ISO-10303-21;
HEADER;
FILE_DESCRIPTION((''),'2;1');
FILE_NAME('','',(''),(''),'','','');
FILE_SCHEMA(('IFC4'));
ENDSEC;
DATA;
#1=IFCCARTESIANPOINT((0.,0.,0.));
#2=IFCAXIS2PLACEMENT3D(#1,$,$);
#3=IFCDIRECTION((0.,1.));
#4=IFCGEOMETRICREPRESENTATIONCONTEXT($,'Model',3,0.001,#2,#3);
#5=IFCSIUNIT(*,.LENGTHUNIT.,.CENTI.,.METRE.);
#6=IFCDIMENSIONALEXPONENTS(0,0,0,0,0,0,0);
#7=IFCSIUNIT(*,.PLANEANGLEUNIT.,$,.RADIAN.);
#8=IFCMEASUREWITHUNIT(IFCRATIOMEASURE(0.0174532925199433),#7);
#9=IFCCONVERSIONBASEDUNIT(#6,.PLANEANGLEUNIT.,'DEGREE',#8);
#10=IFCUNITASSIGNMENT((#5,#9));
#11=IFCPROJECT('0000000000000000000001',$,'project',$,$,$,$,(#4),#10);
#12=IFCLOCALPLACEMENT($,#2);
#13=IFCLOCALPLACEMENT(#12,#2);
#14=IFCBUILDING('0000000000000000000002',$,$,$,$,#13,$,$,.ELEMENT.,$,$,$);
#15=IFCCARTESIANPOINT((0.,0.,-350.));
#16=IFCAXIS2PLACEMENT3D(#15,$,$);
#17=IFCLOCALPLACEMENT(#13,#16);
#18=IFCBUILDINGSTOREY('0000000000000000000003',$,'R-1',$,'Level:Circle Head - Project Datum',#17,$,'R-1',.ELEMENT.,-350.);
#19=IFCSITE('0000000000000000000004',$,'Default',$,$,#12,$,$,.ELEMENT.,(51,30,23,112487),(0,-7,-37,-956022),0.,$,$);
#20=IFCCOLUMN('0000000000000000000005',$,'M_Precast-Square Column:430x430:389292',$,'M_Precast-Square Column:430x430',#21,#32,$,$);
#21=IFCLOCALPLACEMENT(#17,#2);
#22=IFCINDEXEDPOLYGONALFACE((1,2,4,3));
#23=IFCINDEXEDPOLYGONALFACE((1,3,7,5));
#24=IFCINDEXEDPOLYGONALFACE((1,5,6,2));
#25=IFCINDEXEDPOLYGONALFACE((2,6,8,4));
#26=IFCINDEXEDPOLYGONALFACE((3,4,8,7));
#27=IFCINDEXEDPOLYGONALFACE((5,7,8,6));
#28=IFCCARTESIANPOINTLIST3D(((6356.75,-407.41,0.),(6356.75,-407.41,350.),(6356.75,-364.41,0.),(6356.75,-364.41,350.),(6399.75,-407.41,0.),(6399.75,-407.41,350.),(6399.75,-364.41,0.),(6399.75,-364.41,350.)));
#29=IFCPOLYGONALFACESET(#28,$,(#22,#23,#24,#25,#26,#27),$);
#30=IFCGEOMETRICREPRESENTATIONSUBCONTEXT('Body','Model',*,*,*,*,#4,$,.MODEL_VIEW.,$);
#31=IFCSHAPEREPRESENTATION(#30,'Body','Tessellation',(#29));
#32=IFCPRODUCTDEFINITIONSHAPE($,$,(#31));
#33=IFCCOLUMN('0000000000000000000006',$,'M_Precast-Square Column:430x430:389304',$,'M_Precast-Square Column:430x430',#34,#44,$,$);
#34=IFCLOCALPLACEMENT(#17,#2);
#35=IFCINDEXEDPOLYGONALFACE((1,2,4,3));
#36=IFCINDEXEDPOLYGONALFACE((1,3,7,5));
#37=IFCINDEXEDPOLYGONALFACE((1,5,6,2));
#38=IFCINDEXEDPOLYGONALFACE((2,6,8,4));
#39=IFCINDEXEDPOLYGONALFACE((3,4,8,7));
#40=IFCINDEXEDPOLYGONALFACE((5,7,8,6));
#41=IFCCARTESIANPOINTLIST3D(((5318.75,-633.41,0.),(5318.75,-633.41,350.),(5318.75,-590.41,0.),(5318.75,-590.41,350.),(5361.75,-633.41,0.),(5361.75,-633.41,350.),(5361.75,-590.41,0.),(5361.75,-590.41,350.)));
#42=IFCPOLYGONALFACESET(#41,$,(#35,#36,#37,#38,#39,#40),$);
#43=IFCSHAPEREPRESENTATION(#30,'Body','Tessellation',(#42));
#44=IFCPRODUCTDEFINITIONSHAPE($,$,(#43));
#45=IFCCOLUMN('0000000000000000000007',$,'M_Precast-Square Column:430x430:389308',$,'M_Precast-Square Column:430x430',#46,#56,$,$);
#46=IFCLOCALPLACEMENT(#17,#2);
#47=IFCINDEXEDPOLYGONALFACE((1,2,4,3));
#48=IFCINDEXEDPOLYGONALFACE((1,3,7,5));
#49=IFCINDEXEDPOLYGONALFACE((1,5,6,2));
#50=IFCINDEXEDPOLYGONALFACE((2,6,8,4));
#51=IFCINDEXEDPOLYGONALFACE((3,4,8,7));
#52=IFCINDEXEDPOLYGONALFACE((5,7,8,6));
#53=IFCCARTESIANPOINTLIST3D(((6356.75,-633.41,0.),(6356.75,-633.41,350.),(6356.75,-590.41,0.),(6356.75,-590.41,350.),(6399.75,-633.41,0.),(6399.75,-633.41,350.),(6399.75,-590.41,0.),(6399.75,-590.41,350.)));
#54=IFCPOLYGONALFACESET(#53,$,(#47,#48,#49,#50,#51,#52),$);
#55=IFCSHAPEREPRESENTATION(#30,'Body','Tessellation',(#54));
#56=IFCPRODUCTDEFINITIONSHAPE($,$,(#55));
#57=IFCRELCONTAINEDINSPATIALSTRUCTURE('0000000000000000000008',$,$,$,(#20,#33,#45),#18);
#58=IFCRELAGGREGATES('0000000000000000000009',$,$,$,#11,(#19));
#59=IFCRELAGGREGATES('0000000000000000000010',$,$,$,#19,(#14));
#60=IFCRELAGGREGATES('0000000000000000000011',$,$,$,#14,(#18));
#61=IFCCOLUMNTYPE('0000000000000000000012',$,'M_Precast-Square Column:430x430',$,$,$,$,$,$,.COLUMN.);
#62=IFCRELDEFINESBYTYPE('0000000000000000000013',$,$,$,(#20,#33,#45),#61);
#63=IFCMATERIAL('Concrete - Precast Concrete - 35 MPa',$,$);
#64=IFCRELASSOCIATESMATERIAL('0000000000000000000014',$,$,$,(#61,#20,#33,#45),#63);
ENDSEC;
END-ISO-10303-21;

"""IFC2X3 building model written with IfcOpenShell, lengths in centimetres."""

from ifc_helpers import new_model, entity, si_unit, converted_unit, direction, frame, origin, origin_2d_with_axis, place, context, subcontext, project, spatial, rectangle, extrude, source, transform, mapped, material, type_object, type_shapes, element, save


model = new_model("IFC2X3")

# Units and contexts
model_context = context("Model", 3, precision=0.001, world=origin(), true_north=direction((0.0, 1.0)))
body_context = subcontext(model_context, "Body", "Model", "MODEL_VIEW")
ifc_project = project(units=[si_unit("LENGTHUNIT", "METRE", prefix="CENTI"), converted_unit("PLANEANGLEUNIT", "DEGREE", entity("IfcRatioMeasure", 0.0174532925199433), si_unit("PLANEANGLEUNIT", "RADIAN"), dimensions=[0, 0, 0, 0, 0, 0, 0])], contexts=[model_context])

# Site, building, storey
site_placement = place(None, origin())
site = spatial("IfcSite", under=ifc_project, at=site_placement, Name="Default", CompositionType="ELEMENT", RefLatitude=(51, 30, 23, 112487), RefLongitude=(0, -7, -37, -956022), RefElevation=0.0)
building_placement = place(site_placement, origin())
building = spatial("IfcBuilding", under=site, at=building_placement, CompositionType="ELEMENT")
storey_placement = place(building_placement, frame((0.0, 0.0, -350.0)))
storey = spatial("IfcBuildingStorey", under=building, at=storey_placement, Name="R-1", ObjectType="Level:Circle Head - Project Datum", LongName="R-1", CompositionType="ELEMENT", Elevation=-350.0)

# Columns
ifc_material = material(Name="Concrete - Precast Concrete - 35 MPa")
column_type = type_object("IfcColumnType", Name="M_Precast-Square Column:430x430", PredefinedType="COLUMN", material=ifc_material)
shared_shape = source(origin(), body_context, "Body", "SweptSolid", [
    extrude(rectangle(XDim=43.0, YDim=43.0, at=origin_2d_with_axis()), frame((0.0, 0.0, -350.0), z_axis=(0.0, 0.0, 1.0), x_axis=(0.0, -1.0, 0.0)), (0.0, 0.0, 1.0), 350.0),
])
type_shapes(column_type, [shared_shape])
for number, where, name in (
    (1, (6378.25, -385.91, 350.0), "M_Precast-Square Column:430x430:389292"),
    (2, (5340.25, -611.91, 350.0), "M_Precast-Square Column:430x430:389304"),
    (3, (6378.25, -611.91, 350.0), "M_Precast-Square Column:430x430:389308"),
):
    element("IfcColumn", number, at=place(storey_placement, frame(where)), inside=storey, type_object=column_type, material=ifc_material, Name=name, ObjectType="M_Precast-Square Column:430x430", context=body_context, shape_type="MappedRepresentation", body=[
        mapped(shared_shape, transform((0.0, 0.0, 0.0), scale=1.0)),
    ])

save(model, "model.ifc")
